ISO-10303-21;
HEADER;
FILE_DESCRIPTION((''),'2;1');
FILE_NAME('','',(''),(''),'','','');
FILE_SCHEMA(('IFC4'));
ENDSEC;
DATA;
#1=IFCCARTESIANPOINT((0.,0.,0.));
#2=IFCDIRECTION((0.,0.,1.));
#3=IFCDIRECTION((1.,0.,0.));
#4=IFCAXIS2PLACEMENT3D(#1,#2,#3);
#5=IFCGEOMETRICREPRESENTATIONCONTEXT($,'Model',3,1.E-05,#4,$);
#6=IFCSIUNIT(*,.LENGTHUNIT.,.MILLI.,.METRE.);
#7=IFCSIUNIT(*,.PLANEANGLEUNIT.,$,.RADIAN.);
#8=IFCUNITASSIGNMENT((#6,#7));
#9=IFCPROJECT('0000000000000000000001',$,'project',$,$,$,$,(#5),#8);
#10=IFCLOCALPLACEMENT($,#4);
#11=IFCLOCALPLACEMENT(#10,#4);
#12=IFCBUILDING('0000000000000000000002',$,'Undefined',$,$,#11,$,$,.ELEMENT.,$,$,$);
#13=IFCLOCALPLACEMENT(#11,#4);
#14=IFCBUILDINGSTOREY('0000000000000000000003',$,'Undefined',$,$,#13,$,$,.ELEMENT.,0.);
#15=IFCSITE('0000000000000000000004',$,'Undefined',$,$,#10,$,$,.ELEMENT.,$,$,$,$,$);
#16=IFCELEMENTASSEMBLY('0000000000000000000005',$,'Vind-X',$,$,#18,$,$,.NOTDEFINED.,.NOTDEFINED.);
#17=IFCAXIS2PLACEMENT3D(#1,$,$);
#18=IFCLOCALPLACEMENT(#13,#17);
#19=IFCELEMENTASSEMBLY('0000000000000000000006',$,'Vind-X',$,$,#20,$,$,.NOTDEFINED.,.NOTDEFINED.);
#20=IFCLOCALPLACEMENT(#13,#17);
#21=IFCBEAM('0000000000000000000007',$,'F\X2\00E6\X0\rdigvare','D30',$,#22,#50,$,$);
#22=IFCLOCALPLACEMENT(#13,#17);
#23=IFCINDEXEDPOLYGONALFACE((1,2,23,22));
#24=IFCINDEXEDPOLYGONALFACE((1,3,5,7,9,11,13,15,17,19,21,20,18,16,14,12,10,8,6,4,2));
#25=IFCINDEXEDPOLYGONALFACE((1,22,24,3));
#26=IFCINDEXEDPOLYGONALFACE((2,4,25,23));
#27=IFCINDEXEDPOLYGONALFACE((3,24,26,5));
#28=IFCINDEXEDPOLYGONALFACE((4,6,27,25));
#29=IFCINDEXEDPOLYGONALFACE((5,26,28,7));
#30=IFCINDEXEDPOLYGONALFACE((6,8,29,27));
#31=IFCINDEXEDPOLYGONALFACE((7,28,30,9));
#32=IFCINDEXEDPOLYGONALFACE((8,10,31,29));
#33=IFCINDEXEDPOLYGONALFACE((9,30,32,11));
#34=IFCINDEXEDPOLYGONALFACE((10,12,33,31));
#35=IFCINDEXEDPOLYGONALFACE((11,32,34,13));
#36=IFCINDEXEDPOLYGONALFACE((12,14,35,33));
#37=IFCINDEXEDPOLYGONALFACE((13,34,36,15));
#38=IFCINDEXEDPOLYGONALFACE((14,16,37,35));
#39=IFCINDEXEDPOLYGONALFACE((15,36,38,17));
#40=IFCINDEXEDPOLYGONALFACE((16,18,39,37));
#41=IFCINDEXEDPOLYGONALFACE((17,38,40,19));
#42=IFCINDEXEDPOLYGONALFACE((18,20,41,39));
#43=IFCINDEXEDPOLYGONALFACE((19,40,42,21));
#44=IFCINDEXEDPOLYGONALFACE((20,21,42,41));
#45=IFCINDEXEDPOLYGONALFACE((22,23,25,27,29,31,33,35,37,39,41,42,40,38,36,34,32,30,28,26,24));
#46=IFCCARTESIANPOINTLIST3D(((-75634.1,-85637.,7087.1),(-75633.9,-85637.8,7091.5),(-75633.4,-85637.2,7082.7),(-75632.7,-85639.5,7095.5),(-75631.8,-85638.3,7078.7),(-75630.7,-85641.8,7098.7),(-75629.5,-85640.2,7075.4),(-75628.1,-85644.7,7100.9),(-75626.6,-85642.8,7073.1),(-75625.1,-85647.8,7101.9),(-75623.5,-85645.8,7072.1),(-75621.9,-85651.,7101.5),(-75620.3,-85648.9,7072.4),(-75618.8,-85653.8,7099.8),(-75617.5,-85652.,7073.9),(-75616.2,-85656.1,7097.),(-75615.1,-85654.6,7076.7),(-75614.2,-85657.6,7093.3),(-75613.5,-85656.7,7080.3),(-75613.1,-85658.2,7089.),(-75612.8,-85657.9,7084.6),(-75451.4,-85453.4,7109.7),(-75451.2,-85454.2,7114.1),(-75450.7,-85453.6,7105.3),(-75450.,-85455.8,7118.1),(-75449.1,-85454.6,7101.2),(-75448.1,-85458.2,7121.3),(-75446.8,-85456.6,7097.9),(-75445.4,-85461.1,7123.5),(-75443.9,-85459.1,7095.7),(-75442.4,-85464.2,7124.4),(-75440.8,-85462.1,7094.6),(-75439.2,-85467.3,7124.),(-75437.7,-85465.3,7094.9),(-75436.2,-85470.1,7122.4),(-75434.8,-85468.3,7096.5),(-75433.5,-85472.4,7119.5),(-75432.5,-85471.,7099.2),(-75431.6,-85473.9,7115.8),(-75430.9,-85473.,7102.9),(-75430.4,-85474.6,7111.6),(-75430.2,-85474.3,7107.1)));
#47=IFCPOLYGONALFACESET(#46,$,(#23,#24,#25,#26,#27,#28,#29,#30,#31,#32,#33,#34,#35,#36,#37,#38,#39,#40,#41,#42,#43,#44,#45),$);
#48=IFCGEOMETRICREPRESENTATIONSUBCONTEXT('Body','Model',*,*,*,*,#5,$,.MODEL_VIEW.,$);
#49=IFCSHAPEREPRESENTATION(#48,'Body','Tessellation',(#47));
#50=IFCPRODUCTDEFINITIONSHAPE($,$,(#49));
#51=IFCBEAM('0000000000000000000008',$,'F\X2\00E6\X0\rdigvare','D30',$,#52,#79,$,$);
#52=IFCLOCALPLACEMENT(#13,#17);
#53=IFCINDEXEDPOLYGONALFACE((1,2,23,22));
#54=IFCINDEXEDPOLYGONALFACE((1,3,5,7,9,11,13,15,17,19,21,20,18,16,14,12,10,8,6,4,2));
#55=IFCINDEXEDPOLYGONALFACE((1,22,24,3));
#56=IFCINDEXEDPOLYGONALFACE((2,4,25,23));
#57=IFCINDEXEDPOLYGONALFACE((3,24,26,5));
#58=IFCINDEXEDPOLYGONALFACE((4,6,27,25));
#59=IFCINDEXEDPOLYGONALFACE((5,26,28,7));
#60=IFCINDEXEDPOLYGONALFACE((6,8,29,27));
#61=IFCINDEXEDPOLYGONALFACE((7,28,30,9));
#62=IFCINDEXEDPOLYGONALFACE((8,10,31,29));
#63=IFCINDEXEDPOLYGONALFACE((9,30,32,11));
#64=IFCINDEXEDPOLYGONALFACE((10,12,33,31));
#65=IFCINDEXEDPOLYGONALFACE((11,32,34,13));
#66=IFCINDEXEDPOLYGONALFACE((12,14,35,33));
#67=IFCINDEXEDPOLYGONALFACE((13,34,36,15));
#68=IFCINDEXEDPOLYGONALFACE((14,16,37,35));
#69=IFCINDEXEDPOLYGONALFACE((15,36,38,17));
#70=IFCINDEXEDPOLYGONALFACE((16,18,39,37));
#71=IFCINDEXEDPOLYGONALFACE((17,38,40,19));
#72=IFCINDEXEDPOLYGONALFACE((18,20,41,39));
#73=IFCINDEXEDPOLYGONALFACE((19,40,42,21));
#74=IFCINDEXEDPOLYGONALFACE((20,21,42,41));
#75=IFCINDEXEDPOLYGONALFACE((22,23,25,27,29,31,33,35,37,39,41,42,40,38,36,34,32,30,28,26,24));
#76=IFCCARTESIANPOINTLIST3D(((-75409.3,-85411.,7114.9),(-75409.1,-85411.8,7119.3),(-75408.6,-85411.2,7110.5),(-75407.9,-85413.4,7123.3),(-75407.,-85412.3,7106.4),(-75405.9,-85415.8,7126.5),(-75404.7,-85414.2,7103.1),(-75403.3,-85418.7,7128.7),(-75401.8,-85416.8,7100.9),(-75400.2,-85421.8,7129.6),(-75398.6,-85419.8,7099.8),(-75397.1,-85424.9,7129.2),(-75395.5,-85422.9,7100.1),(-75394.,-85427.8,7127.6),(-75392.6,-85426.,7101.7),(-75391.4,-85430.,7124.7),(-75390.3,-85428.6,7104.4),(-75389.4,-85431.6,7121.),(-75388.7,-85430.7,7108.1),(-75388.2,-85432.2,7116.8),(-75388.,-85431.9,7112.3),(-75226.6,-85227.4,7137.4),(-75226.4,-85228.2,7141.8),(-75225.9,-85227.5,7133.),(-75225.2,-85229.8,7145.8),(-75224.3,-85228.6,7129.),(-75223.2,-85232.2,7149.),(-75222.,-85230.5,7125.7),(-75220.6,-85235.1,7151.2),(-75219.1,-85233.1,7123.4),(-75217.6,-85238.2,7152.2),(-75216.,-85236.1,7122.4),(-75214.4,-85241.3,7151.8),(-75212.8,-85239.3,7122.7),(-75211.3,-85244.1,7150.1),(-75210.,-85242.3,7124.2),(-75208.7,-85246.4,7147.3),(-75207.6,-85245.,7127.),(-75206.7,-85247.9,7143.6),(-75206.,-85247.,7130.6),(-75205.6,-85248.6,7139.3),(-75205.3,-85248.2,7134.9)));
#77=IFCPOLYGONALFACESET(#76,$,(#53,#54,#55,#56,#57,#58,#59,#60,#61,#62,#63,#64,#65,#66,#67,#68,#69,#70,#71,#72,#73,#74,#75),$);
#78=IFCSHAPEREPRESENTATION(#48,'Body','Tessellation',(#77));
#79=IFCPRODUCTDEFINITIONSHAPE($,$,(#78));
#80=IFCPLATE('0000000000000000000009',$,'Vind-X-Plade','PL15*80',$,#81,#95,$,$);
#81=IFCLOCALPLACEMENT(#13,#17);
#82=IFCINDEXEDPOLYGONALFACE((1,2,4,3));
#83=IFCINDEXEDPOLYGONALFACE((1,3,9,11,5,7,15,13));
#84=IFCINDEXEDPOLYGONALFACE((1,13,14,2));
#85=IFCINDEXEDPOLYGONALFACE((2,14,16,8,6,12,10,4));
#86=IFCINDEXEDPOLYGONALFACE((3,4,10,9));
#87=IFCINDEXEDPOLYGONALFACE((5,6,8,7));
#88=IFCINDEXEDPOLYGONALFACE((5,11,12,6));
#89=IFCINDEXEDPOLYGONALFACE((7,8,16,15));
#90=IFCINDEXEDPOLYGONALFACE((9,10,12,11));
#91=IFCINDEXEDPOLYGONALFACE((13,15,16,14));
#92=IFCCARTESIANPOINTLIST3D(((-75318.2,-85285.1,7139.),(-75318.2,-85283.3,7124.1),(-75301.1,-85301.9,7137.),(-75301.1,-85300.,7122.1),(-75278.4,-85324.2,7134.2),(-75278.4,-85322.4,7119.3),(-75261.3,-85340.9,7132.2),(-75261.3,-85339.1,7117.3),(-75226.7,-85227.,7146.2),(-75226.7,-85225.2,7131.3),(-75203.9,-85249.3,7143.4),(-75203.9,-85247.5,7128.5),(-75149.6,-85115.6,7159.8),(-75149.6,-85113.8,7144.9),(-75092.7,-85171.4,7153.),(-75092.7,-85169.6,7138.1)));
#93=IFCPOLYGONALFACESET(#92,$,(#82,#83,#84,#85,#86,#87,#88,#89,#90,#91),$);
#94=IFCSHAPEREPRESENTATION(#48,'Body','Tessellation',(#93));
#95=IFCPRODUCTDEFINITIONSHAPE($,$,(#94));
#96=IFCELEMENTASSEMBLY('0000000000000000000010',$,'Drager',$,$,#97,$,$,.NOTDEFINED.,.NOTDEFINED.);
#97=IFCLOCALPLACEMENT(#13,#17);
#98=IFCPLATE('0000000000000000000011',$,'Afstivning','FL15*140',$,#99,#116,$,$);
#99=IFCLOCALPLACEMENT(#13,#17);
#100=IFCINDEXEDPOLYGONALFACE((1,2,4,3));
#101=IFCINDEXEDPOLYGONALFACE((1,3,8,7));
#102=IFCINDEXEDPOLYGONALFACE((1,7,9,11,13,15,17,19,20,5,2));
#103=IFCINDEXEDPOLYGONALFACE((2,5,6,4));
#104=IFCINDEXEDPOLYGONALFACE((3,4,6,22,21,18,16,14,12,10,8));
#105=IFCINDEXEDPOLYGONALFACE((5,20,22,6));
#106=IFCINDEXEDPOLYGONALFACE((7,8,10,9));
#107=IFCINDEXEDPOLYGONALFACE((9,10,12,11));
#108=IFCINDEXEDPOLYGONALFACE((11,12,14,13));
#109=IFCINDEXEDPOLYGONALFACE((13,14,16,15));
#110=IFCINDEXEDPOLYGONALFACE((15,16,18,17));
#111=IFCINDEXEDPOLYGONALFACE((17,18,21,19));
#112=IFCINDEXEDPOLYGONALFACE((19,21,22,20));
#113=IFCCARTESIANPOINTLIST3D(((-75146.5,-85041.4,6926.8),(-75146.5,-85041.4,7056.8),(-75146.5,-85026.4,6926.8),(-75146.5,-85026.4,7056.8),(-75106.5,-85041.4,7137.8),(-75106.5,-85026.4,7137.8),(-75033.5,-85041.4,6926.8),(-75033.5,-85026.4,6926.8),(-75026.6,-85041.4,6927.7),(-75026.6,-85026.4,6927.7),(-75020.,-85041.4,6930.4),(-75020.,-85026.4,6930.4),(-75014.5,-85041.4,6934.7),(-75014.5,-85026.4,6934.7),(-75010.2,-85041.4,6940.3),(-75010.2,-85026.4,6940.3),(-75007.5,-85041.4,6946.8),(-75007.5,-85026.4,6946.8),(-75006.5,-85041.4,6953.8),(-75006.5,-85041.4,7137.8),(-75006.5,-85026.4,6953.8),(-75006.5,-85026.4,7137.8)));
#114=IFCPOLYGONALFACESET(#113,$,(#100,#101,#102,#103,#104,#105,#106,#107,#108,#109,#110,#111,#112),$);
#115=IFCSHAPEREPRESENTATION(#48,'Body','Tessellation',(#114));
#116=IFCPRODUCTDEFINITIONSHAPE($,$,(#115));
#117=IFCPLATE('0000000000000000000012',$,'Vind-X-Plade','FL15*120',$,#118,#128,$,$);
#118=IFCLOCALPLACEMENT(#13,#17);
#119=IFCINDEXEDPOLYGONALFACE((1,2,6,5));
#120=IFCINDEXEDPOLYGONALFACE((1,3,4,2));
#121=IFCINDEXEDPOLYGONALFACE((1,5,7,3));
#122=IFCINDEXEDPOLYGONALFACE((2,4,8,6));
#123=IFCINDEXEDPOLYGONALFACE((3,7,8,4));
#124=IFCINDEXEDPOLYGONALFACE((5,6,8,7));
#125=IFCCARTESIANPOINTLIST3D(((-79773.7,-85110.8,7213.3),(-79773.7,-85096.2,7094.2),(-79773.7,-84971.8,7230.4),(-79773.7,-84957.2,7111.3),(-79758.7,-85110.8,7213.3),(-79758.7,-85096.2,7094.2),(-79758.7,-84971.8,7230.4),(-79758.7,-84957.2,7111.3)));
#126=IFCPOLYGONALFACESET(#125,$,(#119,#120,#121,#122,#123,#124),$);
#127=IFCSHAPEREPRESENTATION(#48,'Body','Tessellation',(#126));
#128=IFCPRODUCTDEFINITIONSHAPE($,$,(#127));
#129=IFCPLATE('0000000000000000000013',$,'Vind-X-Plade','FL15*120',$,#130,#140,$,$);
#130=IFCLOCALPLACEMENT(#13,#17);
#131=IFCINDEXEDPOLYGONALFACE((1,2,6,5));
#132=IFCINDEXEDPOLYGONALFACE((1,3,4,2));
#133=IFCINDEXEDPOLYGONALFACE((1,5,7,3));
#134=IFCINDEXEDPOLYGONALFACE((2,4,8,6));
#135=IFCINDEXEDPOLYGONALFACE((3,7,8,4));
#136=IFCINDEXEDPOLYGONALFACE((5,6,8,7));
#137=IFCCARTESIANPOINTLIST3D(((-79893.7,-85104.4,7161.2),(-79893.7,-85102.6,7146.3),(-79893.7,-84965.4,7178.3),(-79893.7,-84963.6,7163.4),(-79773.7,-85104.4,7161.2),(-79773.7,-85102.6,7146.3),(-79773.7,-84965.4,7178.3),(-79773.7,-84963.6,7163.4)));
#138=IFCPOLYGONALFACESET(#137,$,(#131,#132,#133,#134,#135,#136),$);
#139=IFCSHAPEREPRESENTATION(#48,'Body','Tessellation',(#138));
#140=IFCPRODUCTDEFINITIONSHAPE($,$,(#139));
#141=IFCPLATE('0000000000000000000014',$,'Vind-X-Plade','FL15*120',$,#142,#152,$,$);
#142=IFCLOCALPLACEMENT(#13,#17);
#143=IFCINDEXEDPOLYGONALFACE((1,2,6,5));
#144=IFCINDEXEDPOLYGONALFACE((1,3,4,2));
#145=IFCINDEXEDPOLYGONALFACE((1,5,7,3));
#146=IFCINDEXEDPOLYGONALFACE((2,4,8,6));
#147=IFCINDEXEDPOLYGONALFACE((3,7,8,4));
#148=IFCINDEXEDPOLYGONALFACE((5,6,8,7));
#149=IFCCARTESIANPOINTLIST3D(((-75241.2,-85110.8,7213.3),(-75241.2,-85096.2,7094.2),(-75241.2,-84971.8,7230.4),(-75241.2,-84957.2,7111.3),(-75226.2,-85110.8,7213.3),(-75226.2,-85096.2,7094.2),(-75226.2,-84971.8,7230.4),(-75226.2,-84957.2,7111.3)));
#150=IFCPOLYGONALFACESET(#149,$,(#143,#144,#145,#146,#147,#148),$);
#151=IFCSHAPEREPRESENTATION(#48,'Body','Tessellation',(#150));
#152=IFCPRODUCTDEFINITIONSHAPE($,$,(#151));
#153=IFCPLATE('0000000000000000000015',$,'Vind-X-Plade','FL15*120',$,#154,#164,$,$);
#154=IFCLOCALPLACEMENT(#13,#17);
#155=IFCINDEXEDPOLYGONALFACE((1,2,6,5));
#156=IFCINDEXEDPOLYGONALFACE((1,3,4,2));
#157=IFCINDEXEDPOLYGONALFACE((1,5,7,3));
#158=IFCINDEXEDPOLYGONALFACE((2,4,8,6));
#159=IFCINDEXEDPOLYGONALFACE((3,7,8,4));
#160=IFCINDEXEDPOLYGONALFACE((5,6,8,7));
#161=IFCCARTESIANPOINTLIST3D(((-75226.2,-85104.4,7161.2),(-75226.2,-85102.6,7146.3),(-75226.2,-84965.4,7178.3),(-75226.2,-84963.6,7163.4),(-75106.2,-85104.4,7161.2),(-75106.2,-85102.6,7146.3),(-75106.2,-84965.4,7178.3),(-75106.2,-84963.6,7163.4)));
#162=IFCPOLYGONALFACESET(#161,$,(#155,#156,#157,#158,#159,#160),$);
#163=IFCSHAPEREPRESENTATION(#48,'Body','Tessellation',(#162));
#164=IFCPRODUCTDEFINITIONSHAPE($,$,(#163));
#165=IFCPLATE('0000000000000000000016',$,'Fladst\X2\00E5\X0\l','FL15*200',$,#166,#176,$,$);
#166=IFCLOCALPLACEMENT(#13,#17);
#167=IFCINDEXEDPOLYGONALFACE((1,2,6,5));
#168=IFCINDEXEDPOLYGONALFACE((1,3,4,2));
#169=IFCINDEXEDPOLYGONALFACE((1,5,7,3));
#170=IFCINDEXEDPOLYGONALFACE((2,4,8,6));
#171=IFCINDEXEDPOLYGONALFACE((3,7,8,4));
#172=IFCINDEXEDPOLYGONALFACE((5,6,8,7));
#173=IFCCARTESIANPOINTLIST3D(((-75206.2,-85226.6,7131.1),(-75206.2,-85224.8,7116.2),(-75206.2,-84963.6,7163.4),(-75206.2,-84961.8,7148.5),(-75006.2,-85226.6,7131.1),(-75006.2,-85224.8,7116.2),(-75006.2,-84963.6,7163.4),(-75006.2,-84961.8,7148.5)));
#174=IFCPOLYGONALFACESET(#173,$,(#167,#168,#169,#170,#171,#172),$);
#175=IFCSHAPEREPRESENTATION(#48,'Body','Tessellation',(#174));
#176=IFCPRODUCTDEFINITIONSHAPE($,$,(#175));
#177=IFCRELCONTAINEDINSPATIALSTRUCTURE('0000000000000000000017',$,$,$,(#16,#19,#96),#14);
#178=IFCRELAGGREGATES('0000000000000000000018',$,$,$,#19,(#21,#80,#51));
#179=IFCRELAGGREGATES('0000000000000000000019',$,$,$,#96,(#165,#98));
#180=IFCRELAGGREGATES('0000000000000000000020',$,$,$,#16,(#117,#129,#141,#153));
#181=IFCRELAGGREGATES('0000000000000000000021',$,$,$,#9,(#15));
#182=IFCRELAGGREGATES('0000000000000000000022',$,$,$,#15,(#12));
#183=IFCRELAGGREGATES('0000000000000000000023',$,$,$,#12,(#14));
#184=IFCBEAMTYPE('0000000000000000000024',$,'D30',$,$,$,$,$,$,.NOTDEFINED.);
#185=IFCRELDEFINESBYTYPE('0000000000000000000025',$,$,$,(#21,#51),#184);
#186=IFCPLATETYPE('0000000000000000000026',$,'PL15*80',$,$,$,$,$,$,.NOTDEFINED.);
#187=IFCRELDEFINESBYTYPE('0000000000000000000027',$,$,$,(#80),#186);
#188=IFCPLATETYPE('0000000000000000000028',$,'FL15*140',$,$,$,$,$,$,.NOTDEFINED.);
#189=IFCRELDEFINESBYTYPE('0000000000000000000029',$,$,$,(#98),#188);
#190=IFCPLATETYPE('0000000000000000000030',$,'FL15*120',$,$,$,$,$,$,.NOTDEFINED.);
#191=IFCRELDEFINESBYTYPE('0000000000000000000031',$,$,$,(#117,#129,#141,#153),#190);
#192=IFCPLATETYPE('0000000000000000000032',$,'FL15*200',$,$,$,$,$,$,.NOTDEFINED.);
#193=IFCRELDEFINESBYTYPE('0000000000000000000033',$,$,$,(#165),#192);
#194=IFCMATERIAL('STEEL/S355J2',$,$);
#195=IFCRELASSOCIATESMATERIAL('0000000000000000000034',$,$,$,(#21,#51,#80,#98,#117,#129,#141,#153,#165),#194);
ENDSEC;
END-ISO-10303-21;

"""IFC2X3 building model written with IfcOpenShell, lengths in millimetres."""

from ifc_helpers import new_model, si_unit, frame, frame_2d, origin_with_axes, origin_2d_with_axis, place, context, subcontext, project, spatial, polyline, circle_curve, parameter, trimmed, segment, composite_curve, circle, outline, extrude, boolean, material, type_object, element, aggregate, save


model = new_model("IFC2X3")

# Units and contexts
model_context = context("Model", 3, precision=1e-05, world=origin_with_axes())
body_context = subcontext(model_context, "Body", "Model", "MODEL_VIEW")
ifc_project = project(units=[si_unit("LENGTHUNIT", "METRE", prefix="MILLI"), si_unit("PLANEANGLEUNIT", "RADIAN")], contexts=[model_context])

# Site, building, storey
site_placement = place(None, origin_with_axes())
site = spatial("IfcSite", under=ifc_project, at=site_placement, Name="Undefined", CompositionType="ELEMENT")
building_placement = place(site_placement, origin_with_axes())
building = spatial("IfcBuilding", under=site, at=building_placement, Name="Undefined", CompositionType="ELEMENT")
storey_placement = place(building_placement, origin_with_axes())
storey = spatial("IfcBuildingStorey", under=building, at=storey_placement, Name="Undefined", CompositionType="ELEMENT", Elevation=0.0)

# Element assemblies
assembly_1_placement = place(storey_placement, origin_with_axes())
assembly_1 = element("IfcElementAssembly", 1, at=assembly_1_placement, inside=storey, Name="Vind-X", AssemblyPlace="NOTDEFINED", PredefinedType="NOTDEFINED")
assembly_2_placement = place(storey_placement, origin_with_axes())
assembly_2 = element("IfcElementAssembly", 2, at=assembly_2_placement, inside=storey, Name="Vind-X", AssemblyPlace="NOTDEFINED", PredefinedType="NOTDEFINED")
ifc_material_1 = material(Name="STEEL/S355J2")

# Beams
beam_type_1 = type_object("IfcBeamType", Name="D30", PredefinedType="NOTDEFINED")
beam_1_placement = place(assembly_2_placement, frame((-75440.8, -85464.0, 7109.5), z_axis=(-0.711591, 0.697357, 0.085625), x_axis=(-0.702594, -0.706287, -0.086721)))
beam_1 = element("IfcBeam", 3, at=beam_1_placement, type_object=beam_type_1, material=ifc_material_1, Name="Færdigvare", Description="D30", context=body_context, shape_type="SweptSolid", body=[
    extrude(circle(Radius=15.0, at=origin_2d_with_axis()), frame((260.0, 0.0, 0.0), z_axis=(-1.0, 0.0, 0.0), x_axis=(0.0, -1.0, 0.0)), (0.0, 0.0, 1.0), 260.0),
])
beam_2_placement = place(assembly_2_placement, frame((-75216.0, -85237.9, 7137.3), z_axis=(-0.711592, 0.697356, 0.085625), x_axis=(-0.702593, -0.706288, -0.086721)))
beam_2 = element("IfcBeam", 4, at=beam_2_placement, type_object=beam_type_1, material=ifc_material_1, Name="Færdigvare", Description="D30", context=body_context, shape_type="SweptSolid", body=[
    extrude(circle(Radius=15.0, at=origin_2d_with_axis()), frame((260.0, 0.0, 0.0), z_axis=(-1.0, 0.0, 0.0), x_axis=(0.0, -1.0, 0.0)), (0.0, 0.0, 1.0), 260.0),
])

# Plate
plate_type_1 = type_object("IfcPlateType", Name="PL15*80", PredefinedType="NOTDEFINED")
plate_1_placement = place(assembly_2_placement, frame((-75092.7, -85170.5, 7145.5), z_axis=(0.0, -0.121869, 0.992546), x_axis=(-0.711592, 0.697356, 0.085625)))
plate_1 = element("IfcPlate", 5, at=plate_1_placement, type_object=plate_type_1, material=ifc_material_1, Name="Vind-X-Plade", Description="PL15*80", context=body_context, shape_type="CSG", body=[
    boolean("DIFFERENCE", extrude(outline(polyline([(0.0, 0.0), (80.0, 0.0), (80.0, 240.0), (0.0, 240.0), (0.0, 0.0)])), frame((0.0, 0.0, -7.5), z_axis=(0.0, 0.0, 1.0), x_axis=(1.0, 0.0, 0.0)), (0.0, 0.0, 1.0), 15.0), extrude(outline(polyline([(0.0, 0.0), (106.0, 0.0), (106.0, 32.0), (0.0, 32.0), (0.0, 0.0)])), frame((56.0, 240.0, 8.5), z_axis=(0.0, 0.0, -1.0), x_axis=(0.0, -1.0, 0.0)), (0.0, 0.0, 1.0), 17.0)),
])

# Element assembly, plate
assembly_3_placement = place(storey_placement, origin_with_axes())
assembly_3 = element("IfcElementAssembly", 6, at=assembly_3_placement, inside=storey, Name="Drager", AssemblyPlace="NOTDEFINED", PredefinedType="NOTDEFINED")
plate_type_2 = type_object("IfcPlateType", Name="FL15*140", PredefinedType="NOTDEFINED")
plate_2_placement = place(assembly_3_placement, frame((-75146.5, -85033.9, 6926.8), z_axis=(0.0, -1.0, 0.0), x_axis=(1.0, 0.0, 0.0)))
plate_2 = element("IfcPlate", 7, at=plate_2_placement, type_object=plate_type_2, material=ifc_material_1, Name="Afstivning", Description="FL15*140", context=body_context, shape_type="SweptSolid", body=[
    extrude(outline(composite_curve([segment(polyline([(0.0, 0.0), (113.0, 0.0)]), True, "CONTINUOUS"), segment(trimmed(circle_curve(frame_2d((113.0, 27.0), x_axis=(0.0, -1.0)), 27.0), [parameter(0.0)], [parameter(1.570796)], True, "PARAMETER"), True, "CONTINUOUS"), segment(polyline([(140.0, 27.0), (140.0, 211.0), (40.0, 211.0), (0.0, 130.0), (0.0, 0.0)]), True, "CONTINUOUS")], self_intersect=True)), frame((0.0, 0.0, -7.5), z_axis=(0.0, 0.0, 1.0), x_axis=(1.0, 0.0, 0.0)), (0.0, 0.0, 1.0), 15.0),
])

# Plates
plate_type_3 = type_object("IfcPlateType", Name="FL15*120", PredefinedType="NOTDEFINED")
plate_3_placement = place(assembly_1_placement, frame((-79766.2, -84957.2, 7111.3), z_axis=(-1.0, 0.0, 0.0), x_axis=(0.0, -0.992546, -0.121869)))
plate_3 = element("IfcPlate", 8, at=plate_3_placement, type_object=plate_type_3, material=ifc_material_1, Name="Vind-X-Plade", Description="FL15*120", context=body_context, shape_type="SweptSolid", body=[
    extrude(outline(polyline([(0.0, 0.0), (140.0, 0.0), (140.0, 120.0), (0.0, 120.0), (0.0, 0.0)])), frame((0.0, 0.0, -7.5), z_axis=(0.0, 0.0, 1.0), x_axis=(1.0, 0.0, 0.0)), (0.0, 0.0, 1.0), 15.0),
])
plate_4_placement = place(assembly_1_placement, frame((-79893.7, -85034.0, 7162.3), z_axis=(0.0, 0.121869, -0.992546), x_axis=(1.0, 0.0, 0.0)))
plate_4 = element("IfcPlate", 9, at=plate_4_placement, type_object=plate_type_3, material=ifc_material_1, Name="Vind-X-Plade", Description="FL15*120", context=body_context, shape_type="SweptSolid", body=[
    extrude(outline(polyline([(0.0, -70.0), (0.0, 70.0), (120.0, 70.0), (120.0, -70.0), (0.0, -70.0)])), frame((0.0, 0.0, -7.5), z_axis=(0.0, 0.0, 1.0), x_axis=(1.0, 0.0, 0.0)), (0.0, 0.0, 1.0), 15.0),
])
plate_5_placement = place(assembly_1_placement, frame((-75233.7, -85096.2, 7094.2), z_axis=(1.0, 0.0, 0.0), x_axis=(0.0, 0.992546, 0.121869)))
plate_5 = element("IfcPlate", 10, at=plate_5_placement, type_object=plate_type_3, material=ifc_material_1, Name="Vind-X-Plade", Description="FL15*120", context=body_context, shape_type="SweptSolid", body=[
    extrude(outline(polyline([(0.0, 0.0), (140.0, 0.0), (140.0, 120.0), (0.0, 120.0), (0.0, 0.0)])), frame((0.0, 0.0, -7.5), z_axis=(0.0, 0.0, 1.0), x_axis=(1.0, 0.0, 0.0)), (0.0, 0.0, 1.0), 15.0),
])
plate_6_placement = place(assembly_1_placement, frame((-75106.2, -85034.0, 7162.3), z_axis=(0.0, 0.121869, -0.992546), x_axis=(-1.0, 0.0, 0.0)))
plate_6 = element("IfcPlate", 11, at=plate_6_placement, type_object=plate_type_3, material=ifc_material_1, Name="Vind-X-Plade", Description="FL15*120", context=body_context, shape_type="SweptSolid", body=[
    extrude(outline(polyline([(0.0, -70.0), (0.0, 70.0), (120.0, 70.0), (120.0, -70.0), (0.0, -70.0)])), frame((0.0, 0.0, -7.5), z_axis=(0.0, 0.0, 1.0), x_axis=(1.0, 0.0, 0.0)), (0.0, 0.0, 1.0), 15.0),
])
plate_type_4 = type_object("IfcPlateType", Name="FL15*200", PredefinedType="NOTDEFINED")
plate_7_placement = place(assembly_3_placement, frame((-75006.2, -85225.7, 7123.6), z_axis=(0.0, -0.121869, 0.992546), x_axis=(0.0, 0.992546, 0.121869)))
plate_7 = element("IfcPlate", 12, at=plate_7_placement, type_object=plate_type_4, material=ifc_material_1, Name="Fladstål", Description="FL15*200", context=body_context, shape_type="SweptSolid", body=[
    extrude(outline(polyline([(0.0, 0.0), (265.0, 0.0), (265.0, 200.0), (0.0, 200.0), (0.0, 0.0)])), frame((0.0, 0.0, -7.5), z_axis=(0.0, 0.0, 1.0), x_axis=(1.0, 0.0, 0.0)), (0.0, 0.0, 1.0), 15.0),
])

aggregate(assembly_2, [beam_1, plate_1, beam_2])

aggregate(assembly_3, [plate_7, plate_2])
aggregate(assembly_1, [plate_3, plate_4, plate_5, plate_6])

save(model, "model.ifc")
